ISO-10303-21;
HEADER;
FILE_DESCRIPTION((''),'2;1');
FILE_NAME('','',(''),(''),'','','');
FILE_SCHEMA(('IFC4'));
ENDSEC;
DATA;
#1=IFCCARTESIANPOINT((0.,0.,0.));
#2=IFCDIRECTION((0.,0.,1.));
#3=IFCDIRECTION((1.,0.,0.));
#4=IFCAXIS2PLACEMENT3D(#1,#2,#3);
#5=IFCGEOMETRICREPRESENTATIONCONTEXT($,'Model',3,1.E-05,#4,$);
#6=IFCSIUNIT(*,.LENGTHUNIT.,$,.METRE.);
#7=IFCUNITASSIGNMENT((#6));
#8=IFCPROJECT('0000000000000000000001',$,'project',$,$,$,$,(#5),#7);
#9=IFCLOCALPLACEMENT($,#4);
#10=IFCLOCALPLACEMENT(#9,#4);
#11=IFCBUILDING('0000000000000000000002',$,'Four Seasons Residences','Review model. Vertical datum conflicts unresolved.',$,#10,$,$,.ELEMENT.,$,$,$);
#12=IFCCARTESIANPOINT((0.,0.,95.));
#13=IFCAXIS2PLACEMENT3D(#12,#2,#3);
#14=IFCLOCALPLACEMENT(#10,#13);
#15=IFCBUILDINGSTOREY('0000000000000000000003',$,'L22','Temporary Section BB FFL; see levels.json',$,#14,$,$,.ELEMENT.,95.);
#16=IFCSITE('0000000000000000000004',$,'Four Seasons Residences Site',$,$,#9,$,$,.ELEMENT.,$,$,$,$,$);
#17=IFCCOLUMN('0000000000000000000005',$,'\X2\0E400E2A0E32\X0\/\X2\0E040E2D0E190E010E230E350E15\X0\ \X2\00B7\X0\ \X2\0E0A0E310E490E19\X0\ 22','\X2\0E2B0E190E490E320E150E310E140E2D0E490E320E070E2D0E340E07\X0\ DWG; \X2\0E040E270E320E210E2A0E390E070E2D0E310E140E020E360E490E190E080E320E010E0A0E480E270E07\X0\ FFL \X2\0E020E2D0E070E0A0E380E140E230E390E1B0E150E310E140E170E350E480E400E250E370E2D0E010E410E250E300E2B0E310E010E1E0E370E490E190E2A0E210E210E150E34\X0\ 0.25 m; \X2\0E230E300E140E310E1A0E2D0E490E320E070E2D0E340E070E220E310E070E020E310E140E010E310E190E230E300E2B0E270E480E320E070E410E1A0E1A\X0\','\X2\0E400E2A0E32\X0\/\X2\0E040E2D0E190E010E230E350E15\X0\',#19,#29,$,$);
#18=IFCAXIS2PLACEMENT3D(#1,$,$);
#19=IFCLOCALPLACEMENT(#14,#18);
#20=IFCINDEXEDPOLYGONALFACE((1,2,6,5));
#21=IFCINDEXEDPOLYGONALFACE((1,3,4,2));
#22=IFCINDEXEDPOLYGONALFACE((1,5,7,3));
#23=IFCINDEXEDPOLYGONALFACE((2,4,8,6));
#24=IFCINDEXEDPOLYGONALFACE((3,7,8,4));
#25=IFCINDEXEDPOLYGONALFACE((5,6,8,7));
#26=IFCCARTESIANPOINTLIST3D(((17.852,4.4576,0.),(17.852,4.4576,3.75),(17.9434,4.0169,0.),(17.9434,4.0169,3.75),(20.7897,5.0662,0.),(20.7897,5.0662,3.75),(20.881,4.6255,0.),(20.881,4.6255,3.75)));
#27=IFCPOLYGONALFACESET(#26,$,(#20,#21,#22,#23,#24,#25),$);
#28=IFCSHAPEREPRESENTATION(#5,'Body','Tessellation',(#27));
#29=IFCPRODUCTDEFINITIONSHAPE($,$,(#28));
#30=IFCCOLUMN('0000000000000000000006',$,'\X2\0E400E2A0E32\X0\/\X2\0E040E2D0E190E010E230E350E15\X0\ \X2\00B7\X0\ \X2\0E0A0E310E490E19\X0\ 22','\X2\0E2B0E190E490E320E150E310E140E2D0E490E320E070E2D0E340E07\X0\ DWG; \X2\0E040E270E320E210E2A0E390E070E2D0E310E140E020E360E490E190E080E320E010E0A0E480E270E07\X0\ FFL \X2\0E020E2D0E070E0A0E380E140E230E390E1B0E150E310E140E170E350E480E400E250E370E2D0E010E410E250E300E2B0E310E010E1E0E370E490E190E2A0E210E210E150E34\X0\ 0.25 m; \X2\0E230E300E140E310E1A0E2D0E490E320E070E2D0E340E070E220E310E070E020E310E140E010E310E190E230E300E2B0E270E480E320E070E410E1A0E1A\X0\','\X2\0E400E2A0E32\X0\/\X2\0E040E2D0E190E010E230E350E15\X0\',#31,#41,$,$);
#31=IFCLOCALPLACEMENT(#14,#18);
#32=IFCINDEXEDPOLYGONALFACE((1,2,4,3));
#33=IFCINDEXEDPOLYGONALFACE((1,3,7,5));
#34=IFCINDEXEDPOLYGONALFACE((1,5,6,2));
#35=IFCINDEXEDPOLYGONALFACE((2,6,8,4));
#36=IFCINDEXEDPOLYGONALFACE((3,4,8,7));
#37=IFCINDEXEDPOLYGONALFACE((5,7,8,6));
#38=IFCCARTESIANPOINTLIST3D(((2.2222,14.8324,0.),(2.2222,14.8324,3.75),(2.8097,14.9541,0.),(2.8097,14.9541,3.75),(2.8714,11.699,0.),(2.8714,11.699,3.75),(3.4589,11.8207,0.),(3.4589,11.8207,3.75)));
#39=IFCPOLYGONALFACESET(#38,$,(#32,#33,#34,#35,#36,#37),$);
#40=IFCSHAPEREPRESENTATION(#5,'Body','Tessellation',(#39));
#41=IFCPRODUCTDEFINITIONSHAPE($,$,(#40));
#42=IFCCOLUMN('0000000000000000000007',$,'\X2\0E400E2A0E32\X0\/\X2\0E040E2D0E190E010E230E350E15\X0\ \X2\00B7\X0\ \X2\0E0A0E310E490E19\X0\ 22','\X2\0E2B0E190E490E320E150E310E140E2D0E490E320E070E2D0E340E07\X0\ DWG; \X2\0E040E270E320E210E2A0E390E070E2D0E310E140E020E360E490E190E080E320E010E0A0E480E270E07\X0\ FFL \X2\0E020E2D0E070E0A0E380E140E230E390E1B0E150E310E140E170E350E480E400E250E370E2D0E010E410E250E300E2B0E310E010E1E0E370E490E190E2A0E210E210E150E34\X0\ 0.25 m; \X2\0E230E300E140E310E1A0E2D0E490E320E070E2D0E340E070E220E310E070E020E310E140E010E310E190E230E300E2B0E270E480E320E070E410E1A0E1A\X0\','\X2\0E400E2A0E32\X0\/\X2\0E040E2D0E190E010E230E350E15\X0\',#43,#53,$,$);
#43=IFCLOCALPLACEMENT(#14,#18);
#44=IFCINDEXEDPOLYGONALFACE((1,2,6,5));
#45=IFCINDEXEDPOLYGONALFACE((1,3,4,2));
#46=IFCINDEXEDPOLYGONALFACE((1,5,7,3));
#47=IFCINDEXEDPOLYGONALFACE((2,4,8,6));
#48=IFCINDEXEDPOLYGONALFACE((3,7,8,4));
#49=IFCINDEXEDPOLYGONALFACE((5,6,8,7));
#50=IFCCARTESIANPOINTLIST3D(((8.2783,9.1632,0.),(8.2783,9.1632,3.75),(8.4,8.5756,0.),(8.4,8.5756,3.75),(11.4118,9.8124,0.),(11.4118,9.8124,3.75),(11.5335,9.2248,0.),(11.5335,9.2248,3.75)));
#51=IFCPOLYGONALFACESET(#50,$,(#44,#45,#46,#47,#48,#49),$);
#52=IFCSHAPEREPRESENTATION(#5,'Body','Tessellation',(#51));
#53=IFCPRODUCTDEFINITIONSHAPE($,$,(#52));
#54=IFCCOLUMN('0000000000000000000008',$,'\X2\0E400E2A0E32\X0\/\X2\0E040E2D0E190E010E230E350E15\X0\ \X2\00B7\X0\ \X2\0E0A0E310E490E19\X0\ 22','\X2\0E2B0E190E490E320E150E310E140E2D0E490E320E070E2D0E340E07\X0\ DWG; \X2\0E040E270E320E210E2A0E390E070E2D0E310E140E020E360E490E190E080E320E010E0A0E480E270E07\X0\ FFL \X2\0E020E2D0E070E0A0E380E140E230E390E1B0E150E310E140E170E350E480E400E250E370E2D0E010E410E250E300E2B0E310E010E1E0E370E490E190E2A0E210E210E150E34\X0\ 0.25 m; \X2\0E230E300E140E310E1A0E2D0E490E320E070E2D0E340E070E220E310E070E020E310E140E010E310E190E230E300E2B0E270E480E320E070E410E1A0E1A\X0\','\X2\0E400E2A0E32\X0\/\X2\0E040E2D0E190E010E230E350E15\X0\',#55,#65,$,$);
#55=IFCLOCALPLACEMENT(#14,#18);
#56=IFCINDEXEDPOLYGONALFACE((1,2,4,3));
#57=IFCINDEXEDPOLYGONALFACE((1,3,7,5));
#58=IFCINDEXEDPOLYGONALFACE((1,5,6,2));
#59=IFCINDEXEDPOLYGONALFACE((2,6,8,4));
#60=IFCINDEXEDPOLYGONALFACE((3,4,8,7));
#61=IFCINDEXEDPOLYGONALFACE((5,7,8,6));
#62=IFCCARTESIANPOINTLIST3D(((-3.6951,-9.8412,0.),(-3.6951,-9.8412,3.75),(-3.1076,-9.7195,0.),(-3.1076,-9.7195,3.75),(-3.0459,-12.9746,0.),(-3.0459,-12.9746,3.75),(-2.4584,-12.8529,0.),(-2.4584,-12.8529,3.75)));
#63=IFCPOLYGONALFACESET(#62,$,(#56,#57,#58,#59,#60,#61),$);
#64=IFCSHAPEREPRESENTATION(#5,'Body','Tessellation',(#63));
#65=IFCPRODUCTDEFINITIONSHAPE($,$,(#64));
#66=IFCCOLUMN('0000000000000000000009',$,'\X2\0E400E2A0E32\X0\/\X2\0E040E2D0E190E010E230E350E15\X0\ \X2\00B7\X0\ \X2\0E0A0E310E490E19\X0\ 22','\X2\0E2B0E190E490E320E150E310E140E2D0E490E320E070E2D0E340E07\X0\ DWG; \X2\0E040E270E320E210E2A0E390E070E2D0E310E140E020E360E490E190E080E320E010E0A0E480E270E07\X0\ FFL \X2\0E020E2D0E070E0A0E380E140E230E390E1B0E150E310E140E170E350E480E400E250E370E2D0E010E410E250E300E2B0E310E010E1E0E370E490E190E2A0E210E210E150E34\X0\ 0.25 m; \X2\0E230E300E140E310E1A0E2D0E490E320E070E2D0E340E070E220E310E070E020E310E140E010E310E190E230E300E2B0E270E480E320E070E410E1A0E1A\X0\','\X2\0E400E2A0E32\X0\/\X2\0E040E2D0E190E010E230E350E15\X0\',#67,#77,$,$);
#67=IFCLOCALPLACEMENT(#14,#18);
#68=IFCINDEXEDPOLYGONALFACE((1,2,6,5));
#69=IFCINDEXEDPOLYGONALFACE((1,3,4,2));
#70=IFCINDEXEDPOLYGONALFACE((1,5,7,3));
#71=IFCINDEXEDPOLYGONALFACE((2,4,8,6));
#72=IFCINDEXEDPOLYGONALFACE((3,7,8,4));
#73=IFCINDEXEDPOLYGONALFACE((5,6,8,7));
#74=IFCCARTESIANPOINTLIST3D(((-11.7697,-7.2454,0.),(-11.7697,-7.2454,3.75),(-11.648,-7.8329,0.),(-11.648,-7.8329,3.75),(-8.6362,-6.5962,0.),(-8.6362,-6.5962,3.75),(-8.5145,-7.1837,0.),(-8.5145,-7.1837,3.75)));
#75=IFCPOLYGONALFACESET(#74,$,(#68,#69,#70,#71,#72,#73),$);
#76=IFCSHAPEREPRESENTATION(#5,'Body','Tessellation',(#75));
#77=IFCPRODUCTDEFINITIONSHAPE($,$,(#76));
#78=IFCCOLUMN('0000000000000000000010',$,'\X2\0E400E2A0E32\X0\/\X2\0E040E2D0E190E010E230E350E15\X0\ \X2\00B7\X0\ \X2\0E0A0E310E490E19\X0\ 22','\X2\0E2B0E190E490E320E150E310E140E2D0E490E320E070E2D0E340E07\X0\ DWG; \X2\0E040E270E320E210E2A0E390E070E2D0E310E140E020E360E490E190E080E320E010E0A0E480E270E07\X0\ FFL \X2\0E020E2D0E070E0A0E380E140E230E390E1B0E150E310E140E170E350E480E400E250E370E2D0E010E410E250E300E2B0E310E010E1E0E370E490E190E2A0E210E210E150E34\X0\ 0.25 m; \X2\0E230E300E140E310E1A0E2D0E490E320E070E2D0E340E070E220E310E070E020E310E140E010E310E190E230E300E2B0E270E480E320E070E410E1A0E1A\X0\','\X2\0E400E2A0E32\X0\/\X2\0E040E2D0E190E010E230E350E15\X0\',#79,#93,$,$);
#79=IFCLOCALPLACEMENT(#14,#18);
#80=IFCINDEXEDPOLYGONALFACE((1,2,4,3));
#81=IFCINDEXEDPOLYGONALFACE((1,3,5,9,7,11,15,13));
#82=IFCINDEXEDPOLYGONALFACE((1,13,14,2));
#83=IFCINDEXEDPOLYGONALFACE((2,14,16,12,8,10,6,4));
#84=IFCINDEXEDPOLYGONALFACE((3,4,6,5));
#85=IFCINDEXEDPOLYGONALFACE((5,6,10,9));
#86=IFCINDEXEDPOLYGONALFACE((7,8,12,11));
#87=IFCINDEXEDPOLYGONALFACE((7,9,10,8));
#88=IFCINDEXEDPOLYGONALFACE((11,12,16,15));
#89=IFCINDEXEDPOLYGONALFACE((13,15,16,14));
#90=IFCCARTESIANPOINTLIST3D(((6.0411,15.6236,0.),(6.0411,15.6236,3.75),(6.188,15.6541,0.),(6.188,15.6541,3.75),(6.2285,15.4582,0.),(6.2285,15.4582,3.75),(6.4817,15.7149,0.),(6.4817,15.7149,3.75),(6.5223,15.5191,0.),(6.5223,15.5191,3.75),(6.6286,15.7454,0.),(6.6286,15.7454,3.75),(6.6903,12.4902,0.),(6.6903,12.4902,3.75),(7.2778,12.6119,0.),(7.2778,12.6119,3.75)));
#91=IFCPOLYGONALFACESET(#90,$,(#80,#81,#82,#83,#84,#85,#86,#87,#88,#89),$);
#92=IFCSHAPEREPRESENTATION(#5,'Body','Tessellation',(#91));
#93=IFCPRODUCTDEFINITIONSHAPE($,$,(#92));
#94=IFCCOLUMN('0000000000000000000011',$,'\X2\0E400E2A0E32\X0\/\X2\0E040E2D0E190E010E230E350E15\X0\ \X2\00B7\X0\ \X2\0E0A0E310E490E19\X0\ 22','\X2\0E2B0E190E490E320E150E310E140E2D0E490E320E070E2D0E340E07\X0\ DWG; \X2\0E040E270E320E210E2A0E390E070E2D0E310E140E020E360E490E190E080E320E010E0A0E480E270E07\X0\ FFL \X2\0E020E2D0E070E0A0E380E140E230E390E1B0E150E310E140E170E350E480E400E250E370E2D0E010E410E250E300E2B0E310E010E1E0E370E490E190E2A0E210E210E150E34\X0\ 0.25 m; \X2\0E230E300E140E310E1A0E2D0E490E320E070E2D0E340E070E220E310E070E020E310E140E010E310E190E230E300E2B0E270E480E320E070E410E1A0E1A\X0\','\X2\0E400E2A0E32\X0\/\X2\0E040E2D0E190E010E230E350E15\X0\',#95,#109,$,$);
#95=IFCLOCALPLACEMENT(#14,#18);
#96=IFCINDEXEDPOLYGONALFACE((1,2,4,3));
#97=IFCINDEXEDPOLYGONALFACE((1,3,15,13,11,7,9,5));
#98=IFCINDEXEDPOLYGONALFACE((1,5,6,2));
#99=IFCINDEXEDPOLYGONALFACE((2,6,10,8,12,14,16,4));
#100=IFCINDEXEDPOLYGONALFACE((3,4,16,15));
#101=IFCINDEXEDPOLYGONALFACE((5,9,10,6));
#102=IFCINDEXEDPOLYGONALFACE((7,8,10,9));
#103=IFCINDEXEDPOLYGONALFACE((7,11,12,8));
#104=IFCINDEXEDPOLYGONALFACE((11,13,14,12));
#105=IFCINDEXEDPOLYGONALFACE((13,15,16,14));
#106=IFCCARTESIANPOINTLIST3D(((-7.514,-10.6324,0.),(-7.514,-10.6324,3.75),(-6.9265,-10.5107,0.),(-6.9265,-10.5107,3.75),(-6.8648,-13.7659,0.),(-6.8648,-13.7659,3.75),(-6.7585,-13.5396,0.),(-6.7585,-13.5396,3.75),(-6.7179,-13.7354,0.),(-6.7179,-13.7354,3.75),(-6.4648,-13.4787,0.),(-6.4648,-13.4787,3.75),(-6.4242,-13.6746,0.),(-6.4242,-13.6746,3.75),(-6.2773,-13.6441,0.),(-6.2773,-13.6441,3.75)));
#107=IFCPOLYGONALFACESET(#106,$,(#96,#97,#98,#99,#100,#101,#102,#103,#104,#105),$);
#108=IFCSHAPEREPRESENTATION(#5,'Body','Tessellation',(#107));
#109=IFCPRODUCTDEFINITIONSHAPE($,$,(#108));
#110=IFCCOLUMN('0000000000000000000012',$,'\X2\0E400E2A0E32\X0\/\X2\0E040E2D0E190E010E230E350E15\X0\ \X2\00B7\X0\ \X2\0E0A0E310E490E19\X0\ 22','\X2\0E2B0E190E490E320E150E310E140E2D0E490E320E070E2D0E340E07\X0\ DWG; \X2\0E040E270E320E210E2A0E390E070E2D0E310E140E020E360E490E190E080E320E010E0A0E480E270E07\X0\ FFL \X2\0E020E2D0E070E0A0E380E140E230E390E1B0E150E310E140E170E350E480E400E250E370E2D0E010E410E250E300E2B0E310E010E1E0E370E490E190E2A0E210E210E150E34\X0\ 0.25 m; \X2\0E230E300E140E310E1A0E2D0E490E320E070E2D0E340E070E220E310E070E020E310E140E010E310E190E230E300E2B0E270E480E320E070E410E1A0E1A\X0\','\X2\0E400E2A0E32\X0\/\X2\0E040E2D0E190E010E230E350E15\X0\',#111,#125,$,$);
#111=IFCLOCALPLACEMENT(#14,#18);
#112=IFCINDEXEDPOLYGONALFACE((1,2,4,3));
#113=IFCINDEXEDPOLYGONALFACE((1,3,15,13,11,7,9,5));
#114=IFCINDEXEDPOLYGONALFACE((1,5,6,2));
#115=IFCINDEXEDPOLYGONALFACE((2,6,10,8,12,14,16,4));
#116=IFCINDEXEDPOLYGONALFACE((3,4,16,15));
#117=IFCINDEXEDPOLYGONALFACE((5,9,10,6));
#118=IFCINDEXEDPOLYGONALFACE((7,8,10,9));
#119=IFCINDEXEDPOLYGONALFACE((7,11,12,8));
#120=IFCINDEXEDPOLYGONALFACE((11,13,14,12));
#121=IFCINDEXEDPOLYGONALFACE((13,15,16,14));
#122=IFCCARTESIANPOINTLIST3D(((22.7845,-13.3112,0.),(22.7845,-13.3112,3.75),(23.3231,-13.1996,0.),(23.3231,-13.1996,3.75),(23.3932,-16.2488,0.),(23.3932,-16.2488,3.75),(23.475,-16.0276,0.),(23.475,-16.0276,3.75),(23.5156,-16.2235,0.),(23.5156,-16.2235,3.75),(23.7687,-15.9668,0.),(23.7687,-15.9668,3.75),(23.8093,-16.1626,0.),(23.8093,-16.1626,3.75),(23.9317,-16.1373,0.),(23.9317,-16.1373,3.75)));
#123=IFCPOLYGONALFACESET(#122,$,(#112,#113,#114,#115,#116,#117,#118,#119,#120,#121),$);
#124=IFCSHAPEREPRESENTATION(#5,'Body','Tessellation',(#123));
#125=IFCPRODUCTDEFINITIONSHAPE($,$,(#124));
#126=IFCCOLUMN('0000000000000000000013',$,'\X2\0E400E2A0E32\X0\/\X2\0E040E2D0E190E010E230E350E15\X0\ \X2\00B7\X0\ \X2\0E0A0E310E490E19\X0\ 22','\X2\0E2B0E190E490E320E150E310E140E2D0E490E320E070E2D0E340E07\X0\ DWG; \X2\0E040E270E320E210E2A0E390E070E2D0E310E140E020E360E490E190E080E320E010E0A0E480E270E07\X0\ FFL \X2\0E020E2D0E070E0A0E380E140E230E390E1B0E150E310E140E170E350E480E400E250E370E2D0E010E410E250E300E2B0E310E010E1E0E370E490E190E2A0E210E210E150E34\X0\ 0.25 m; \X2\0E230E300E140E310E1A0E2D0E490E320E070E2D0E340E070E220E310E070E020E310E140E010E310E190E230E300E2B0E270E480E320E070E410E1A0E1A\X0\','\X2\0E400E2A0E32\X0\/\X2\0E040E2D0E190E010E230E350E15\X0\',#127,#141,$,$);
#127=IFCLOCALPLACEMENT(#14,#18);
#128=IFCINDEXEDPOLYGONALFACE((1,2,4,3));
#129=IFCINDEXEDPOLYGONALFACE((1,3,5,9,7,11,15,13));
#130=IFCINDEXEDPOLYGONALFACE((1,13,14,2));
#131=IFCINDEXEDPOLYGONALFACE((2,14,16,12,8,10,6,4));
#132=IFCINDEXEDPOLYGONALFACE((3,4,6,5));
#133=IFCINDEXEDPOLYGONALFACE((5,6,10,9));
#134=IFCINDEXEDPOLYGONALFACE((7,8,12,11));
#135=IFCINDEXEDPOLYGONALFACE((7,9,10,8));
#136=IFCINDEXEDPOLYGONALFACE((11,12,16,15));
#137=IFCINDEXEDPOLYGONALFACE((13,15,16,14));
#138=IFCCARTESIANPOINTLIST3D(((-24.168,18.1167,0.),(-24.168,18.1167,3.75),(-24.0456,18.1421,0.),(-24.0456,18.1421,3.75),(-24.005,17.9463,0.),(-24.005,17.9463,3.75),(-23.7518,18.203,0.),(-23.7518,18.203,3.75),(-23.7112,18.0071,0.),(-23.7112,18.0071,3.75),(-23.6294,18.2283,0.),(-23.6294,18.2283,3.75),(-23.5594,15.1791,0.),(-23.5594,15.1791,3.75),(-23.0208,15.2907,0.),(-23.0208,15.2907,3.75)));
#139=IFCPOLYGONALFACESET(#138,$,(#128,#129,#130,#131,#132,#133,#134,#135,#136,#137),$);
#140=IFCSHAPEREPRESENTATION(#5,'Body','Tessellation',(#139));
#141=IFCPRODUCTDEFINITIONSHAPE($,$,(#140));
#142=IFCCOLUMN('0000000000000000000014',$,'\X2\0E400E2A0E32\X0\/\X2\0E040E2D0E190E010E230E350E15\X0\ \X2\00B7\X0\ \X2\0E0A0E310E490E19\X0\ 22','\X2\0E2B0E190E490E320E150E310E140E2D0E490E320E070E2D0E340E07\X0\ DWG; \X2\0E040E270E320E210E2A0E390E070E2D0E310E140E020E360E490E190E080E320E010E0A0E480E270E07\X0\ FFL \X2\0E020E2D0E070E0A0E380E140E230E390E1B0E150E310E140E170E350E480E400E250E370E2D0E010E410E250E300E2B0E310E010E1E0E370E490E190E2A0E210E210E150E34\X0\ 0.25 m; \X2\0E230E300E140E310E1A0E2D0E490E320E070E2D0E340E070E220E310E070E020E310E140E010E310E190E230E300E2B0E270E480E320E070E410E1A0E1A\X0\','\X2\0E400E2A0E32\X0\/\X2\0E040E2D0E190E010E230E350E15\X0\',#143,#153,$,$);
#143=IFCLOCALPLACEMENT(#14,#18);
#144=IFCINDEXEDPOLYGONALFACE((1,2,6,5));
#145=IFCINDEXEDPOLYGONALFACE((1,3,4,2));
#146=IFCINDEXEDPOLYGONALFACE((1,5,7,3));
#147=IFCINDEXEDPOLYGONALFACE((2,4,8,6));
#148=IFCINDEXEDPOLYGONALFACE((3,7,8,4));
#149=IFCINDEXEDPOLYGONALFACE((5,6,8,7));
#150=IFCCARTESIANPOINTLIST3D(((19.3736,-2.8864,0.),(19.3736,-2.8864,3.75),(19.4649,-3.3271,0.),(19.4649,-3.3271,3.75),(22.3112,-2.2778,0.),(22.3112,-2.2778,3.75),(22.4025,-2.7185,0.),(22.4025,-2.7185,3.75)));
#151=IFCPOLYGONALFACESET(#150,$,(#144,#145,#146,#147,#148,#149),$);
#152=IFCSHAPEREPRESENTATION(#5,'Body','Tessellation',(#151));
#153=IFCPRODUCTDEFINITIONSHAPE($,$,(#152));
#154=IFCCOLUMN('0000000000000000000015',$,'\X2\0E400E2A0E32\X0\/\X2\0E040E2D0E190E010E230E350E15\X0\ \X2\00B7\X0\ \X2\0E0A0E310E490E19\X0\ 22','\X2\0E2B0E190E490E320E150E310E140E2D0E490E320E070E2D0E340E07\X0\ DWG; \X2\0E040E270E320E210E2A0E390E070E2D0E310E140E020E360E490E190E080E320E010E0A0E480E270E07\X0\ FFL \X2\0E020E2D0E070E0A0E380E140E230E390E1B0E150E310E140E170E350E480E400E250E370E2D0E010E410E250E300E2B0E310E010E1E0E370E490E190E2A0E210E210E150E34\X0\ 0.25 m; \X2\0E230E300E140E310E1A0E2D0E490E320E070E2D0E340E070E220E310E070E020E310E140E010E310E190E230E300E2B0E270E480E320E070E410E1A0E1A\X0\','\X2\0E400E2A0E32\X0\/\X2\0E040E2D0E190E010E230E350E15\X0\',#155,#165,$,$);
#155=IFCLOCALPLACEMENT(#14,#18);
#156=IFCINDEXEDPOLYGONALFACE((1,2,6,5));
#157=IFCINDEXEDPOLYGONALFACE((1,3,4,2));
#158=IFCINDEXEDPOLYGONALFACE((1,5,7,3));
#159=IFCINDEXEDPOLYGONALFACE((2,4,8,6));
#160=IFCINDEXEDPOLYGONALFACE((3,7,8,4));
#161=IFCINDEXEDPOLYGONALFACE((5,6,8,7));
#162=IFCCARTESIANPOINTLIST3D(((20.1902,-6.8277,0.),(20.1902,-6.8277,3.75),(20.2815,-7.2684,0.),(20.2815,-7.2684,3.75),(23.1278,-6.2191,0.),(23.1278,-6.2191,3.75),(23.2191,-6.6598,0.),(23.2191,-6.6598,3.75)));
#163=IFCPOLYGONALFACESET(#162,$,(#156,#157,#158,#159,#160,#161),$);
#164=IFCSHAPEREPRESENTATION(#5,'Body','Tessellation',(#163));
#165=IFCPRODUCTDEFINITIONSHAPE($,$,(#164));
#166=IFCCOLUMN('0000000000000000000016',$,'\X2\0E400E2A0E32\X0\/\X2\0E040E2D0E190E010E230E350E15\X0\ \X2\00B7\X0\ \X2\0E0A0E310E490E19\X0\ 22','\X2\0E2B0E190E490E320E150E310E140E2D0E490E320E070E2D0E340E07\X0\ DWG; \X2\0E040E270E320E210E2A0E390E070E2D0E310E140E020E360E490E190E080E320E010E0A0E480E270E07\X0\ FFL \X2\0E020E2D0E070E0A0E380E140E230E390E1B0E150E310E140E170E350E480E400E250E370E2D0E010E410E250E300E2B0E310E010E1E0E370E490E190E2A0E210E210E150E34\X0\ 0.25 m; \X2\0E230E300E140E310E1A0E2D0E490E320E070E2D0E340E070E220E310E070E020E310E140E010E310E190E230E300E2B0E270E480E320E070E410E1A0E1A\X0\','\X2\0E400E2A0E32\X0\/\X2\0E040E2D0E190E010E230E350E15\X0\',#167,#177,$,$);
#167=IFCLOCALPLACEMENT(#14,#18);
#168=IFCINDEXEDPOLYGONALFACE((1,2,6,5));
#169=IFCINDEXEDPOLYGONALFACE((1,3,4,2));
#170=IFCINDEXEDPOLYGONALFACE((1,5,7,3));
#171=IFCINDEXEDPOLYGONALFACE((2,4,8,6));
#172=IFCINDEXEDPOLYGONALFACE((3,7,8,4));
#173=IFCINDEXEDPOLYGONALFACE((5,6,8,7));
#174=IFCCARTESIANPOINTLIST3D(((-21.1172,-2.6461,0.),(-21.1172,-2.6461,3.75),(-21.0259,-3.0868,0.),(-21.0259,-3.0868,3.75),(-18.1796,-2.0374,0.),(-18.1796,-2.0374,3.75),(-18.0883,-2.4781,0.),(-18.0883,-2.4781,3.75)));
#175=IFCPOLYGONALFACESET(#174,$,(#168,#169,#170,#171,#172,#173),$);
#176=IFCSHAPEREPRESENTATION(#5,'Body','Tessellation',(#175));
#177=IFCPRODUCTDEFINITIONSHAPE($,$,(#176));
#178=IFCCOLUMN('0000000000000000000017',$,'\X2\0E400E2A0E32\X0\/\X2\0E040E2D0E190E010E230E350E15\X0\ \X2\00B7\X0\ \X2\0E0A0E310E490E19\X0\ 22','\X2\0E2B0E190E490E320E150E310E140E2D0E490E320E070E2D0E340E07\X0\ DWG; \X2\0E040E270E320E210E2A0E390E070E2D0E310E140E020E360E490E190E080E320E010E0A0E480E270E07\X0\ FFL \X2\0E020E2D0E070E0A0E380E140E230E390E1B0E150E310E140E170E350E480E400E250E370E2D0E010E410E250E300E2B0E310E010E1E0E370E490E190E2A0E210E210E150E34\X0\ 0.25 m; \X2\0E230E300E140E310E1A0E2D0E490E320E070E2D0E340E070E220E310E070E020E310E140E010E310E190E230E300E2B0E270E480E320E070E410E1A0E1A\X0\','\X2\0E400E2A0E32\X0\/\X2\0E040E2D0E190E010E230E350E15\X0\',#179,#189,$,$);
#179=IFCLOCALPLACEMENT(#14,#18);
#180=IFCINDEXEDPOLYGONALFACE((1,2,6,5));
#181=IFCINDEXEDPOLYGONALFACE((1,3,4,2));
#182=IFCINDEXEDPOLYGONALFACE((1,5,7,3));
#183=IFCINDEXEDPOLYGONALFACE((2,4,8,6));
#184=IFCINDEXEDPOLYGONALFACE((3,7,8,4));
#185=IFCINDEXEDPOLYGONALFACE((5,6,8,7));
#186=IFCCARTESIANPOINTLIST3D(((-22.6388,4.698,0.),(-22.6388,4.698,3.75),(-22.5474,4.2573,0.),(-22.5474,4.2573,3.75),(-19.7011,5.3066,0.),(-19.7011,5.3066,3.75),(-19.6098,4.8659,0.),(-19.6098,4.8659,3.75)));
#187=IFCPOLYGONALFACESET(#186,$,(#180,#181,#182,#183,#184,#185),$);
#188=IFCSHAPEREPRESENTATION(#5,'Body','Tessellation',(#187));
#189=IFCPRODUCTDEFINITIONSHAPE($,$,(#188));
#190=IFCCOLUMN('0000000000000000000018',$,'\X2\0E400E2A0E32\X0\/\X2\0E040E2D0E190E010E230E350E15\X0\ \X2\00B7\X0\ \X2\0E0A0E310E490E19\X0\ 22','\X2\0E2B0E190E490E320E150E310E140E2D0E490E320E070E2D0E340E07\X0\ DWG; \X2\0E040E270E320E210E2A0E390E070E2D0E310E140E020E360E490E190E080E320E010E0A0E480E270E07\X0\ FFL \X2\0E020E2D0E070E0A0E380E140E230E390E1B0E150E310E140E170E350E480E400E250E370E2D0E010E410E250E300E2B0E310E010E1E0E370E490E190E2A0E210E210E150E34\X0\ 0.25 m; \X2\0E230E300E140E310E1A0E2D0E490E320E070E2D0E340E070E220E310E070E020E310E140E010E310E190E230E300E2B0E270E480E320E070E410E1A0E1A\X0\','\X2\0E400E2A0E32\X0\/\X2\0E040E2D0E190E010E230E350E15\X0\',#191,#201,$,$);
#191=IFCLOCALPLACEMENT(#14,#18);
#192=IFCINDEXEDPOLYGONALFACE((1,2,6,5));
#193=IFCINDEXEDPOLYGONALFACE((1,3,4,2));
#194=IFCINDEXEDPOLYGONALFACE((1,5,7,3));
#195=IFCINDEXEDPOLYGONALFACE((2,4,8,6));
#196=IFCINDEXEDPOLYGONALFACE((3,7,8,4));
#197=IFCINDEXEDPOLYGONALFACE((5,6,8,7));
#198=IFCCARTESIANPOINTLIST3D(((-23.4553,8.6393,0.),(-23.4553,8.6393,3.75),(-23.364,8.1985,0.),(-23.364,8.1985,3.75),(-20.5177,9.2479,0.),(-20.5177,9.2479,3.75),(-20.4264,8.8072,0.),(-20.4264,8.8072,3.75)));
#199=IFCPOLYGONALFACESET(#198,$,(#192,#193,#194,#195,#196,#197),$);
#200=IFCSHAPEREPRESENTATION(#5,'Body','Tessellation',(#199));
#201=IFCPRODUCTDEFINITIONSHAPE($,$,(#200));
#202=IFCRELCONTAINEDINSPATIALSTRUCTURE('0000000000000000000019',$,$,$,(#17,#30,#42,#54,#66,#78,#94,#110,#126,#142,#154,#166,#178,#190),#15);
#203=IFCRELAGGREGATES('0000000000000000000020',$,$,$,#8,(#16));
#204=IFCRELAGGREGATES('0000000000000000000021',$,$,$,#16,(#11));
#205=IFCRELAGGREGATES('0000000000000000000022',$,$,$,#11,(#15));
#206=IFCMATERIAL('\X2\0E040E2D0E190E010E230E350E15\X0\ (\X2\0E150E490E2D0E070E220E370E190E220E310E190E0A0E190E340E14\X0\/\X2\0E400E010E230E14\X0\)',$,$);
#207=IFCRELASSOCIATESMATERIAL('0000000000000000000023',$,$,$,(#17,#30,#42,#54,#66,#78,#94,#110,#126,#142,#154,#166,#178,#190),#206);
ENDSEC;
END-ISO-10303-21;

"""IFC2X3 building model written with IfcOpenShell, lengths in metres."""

from ifc_helpers import new_model, si_unit, frame, origin_with_axes, place, context, project, spatial, polyline, outline, extrude, material, element, save


model = new_model("IFC2X3")

# Units and contexts
model_context = context("Model", 3, precision=1e-05, world=origin_with_axes())
ifc_project = project(units=[si_unit("LENGTHUNIT", "METRE")], contexts=[model_context])

# Site, building, storey
site_placement = place(None, origin_with_axes())
site = spatial("IfcSite", under=ifc_project, at=site_placement, Name="Four Seasons Residences Site", CompositionType="ELEMENT")
building_placement = place(site_placement, origin_with_axes())
building = spatial("IfcBuilding", under=site, at=building_placement, Name="Four Seasons Residences", Description="Review model. Vertical datum conflicts unresolved.", CompositionType="ELEMENT")
storey_placement = place(building_placement, frame((0.0, 0.0, 95.0), z_axis=(0.0, 0.0, 1.0), x_axis=(1.0, 0.0, 0.0)))
storey = spatial("IfcBuildingStorey", under=building, at=storey_placement, Name="L22", Description="Temporary Section BB FFL; see levels.json", CompositionType="ELEMENT", Elevation=95.0)

# Columns
ifc_material_1 = material(Name="คอนกรีต (ต้องยืนยันชนิด/เกรด)")
column_1_placement = place(storey_placement, origin_with_axes())
element("IfcColumn", 1, at=column_1_placement, inside=storey, material=ifc_material_1, Name="เสา/คอนกรีต · ชั้น 22", Description="หน้าตัดอ้างอิง DWG; ความสูงอัดขึ้นจากช่วง FFL ของชุดรูปตัดที่เลือกและหักพื้นสมมติ 0.25 m; ระดับอ้างอิงยังขัดกันระหว่างแบบ", ObjectType="เสา/คอนกรีต", context=model_context, shape_type="SweptSolid", body=[
    extrude(outline(polyline([(20.7897, 5.0662), (20.881, 4.6255), (17.9434, 4.0169), (17.852, 4.4576), (20.7897, 5.0662)])), origin_with_axes(), (0.0, 0.0, 1.0), 3.75),
])
column_2_placement = place(storey_placement, origin_with_axes())
element("IfcColumn", 2, at=column_2_placement, inside=storey, material=ifc_material_1, Name="เสา/คอนกรีต · ชั้น 22", Description="หน้าตัดอ้างอิง DWG; ความสูงอัดขึ้นจากช่วง FFL ของชุดรูปตัดที่เลือกและหักพื้นสมมติ 0.25 m; ระดับอ้างอิงยังขัดกันระหว่างแบบ", ObjectType="เสา/คอนกรีต", context=model_context, shape_type="SweptSolid", body=[
    extrude(outline(polyline([(2.8097, 14.9541), (3.4589, 11.8207), (2.8714, 11.699), (2.2222, 14.8324), (2.8097, 14.9541)])), origin_with_axes(), (0.0, 0.0, 1.0), 3.75),
])
column_3_placement = place(storey_placement, origin_with_axes())
element("IfcColumn", 3, at=column_3_placement, inside=storey, material=ifc_material_1, Name="เสา/คอนกรีต · ชั้น 22", Description="หน้าตัดอ้างอิง DWG; ความสูงอัดขึ้นจากช่วง FFL ของชุดรูปตัดที่เลือกและหักพื้นสมมติ 0.25 m; ระดับอ้างอิงยังขัดกันระหว่างแบบ", ObjectType="เสา/คอนกรีต", context=model_context, shape_type="SweptSolid", body=[
    extrude(outline(polyline([(11.5335, 9.2248), (8.4, 8.5756), (8.2783, 9.1632), (11.4118, 9.8124), (11.5335, 9.2248)])), origin_with_axes(), (0.0, 0.0, 1.0), 3.75),
])
column_4_placement = place(storey_placement, origin_with_axes())
element("IfcColumn", 4, at=column_4_placement, inside=storey, material=ifc_material_1, Name="เสา/คอนกรีต · ชั้น 22", Description="หน้าตัดอ้างอิง DWG; ความสูงอัดขึ้นจากช่วง FFL ของชุดรูปตัดที่เลือกและหักพื้นสมมติ 0.25 m; ระดับอ้างอิงยังขัดกันระหว่างแบบ", ObjectType="เสา/คอนกรีต", context=model_context, shape_type="SweptSolid", body=[
    extrude(outline(polyline([(-3.1076, -9.7195), (-2.4584, -12.8529), (-3.0459, -12.9746), (-3.6951, -9.8412), (-3.1076, -9.7195)])), origin_with_axes(), (0.0, 0.0, 1.0), 3.75),
])
column_5_placement = place(storey_placement, origin_with_axes())
element("IfcColumn", 5, at=column_5_placement, inside=storey, material=ifc_material_1, Name="เสา/คอนกรีต · ชั้น 22", Description="หน้าตัดอ้างอิง DWG; ความสูงอัดขึ้นจากช่วง FFL ของชุดรูปตัดที่เลือกและหักพื้นสมมติ 0.25 m; ระดับอ้างอิงยังขัดกันระหว่างแบบ", ObjectType="เสา/คอนกรีต", context=model_context, shape_type="SweptSolid", body=[
    extrude(outline(polyline([(-8.5145, -7.1837), (-11.648, -7.8329), (-11.7697, -7.2454), (-8.6362, -6.5962), (-8.5145, -7.1837)])), origin_with_axes(), (0.0, 0.0, 1.0), 3.75),
])
column_6_placement = place(storey_placement, origin_with_axes())
element("IfcColumn", 6, at=column_6_placement, inside=storey, material=ifc_material_1, Name="เสา/คอนกรีต · ชั้น 22", Description="หน้าตัดอ้างอิง DWG; ความสูงอัดขึ้นจากช่วง FFL ของชุดรูปตัดที่เลือกและหักพื้นสมมติ 0.25 m; ระดับอ้างอิงยังขัดกันระหว่างแบบ", ObjectType="เสา/คอนกรีต", context=model_context, shape_type="SweptSolid", body=[
    extrude(outline(polyline([(6.6286, 15.7454), (6.4817, 15.7149), (6.5223, 15.5191), (6.2285, 15.4582), (6.188, 15.6541), (6.0411, 15.6236), (6.6903, 12.4902), (7.2778, 12.6119), (6.6286, 15.7454)])), origin_with_axes(), (0.0, 0.0, 1.0), 3.75),
])
column_7_placement = place(storey_placement, origin_with_axes())
element("IfcColumn", 7, at=column_7_placement, inside=storey, material=ifc_material_1, Name="เสา/คอนกรีต · ชั้น 22", Description="หน้าตัดอ้างอิง DWG; ความสูงอัดขึ้นจากช่วง FFL ของชุดรูปตัดที่เลือกและหักพื้นสมมติ 0.25 m; ระดับอ้างอิงยังขัดกันระหว่างแบบ", ObjectType="เสา/คอนกรีต", context=model_context, shape_type="SweptSolid", body=[
    extrude(outline(polyline([(-6.2773, -13.6441), (-6.9265, -10.5107), (-7.514, -10.6324), (-6.8648, -13.7659), (-6.7179, -13.7354), (-6.7585, -13.5396), (-6.4648, -13.4787), (-6.4242, -13.6746), (-6.2773, -13.6441)])), origin_with_axes(), (0.0, 0.0, 1.0), 3.75),
])
column_8_placement = place(storey_placement, origin_with_axes())
element("IfcColumn", 8, at=column_8_placement, inside=storey, material=ifc_material_1, Name="เสา/คอนกรีต · ชั้น 22", Description="หน้าตัดอ้างอิง DWG; ความสูงอัดขึ้นจากช่วง FFL ของชุดรูปตัดที่เลือกและหักพื้นสมมติ 0.25 m; ระดับอ้างอิงยังขัดกันระหว่างแบบ", ObjectType="เสา/คอนกรีต", context=model_context, shape_type="SweptSolid", body=[
    extrude(outline(polyline([(23.9317, -16.1373), (23.3231, -13.1996), (22.7845, -13.3112), (23.3932, -16.2488), (23.5156, -16.2235), (23.475, -16.0276), (23.7687, -15.9668), (23.8093, -16.1626), (23.9317, -16.1373)])), origin_with_axes(), (0.0, 0.0, 1.0), 3.75),
])
column_9_placement = place(storey_placement, origin_with_axes())
element("IfcColumn", 9, at=column_9_placement, inside=storey, material=ifc_material_1, Name="เสา/คอนกรีต · ชั้น 22", Description="หน้าตัดอ้างอิง DWG; ความสูงอัดขึ้นจากช่วง FFL ของชุดรูปตัดที่เลือกและหักพื้นสมมติ 0.25 m; ระดับอ้างอิงยังขัดกันระหว่างแบบ", ObjectType="เสา/คอนกรีต", context=model_context, shape_type="SweptSolid", body=[
    extrude(outline(polyline([(-24.168, 18.1167), (-23.5594, 15.1791), (-23.0208, 15.2907), (-23.6294, 18.2283), (-23.7518, 18.203), (-23.7112, 18.0071), (-24.005, 17.9463), (-24.0456, 18.1421), (-24.168, 18.1167)])), origin_with_axes(), (0.0, 0.0, 1.0), 3.75),
])
column_10_placement = place(storey_placement, origin_with_axes())
element("IfcColumn", 10, at=column_10_placement, inside=storey, material=ifc_material_1, Name="เสา/คอนกรีต · ชั้น 22", Description="หน้าตัดอ้างอิง DWG; ความสูงอัดขึ้นจากช่วง FFL ของชุดรูปตัดที่เลือกและหักพื้นสมมติ 0.25 m; ระดับอ้างอิงยังขัดกันระหว่างแบบ", ObjectType="เสา/คอนกรีต", context=model_context, shape_type="SweptSolid", body=[
    extrude(outline(polyline([(22.3112, -2.2778), (22.4025, -2.7185), (19.4649, -3.3271), (19.3736, -2.8864), (22.3112, -2.2778)])), origin_with_axes(), (0.0, 0.0, 1.0), 3.75),
])
column_11_placement = place(storey_placement, origin_with_axes())
element("IfcColumn", 11, at=column_11_placement, inside=storey, material=ifc_material_1, Name="เสา/คอนกรีต · ชั้น 22", Description="หน้าตัดอ้างอิง DWG; ความสูงอัดขึ้นจากช่วง FFL ของชุดรูปตัดที่เลือกและหักพื้นสมมติ 0.25 m; ระดับอ้างอิงยังขัดกันระหว่างแบบ", ObjectType="เสา/คอนกรีต", context=model_context, shape_type="SweptSolid", body=[
    extrude(outline(polyline([(23.1278, -6.2191), (23.2191, -6.6598), (20.2815, -7.2684), (20.1902, -6.8277), (23.1278, -6.2191)])), origin_with_axes(), (0.0, 0.0, 1.0), 3.75),
])
column_12_placement = place(storey_placement, origin_with_axes())
element("IfcColumn", 12, at=column_12_placement, inside=storey, material=ifc_material_1, Name="เสา/คอนกรีต · ชั้น 22", Description="หน้าตัดอ้างอิง DWG; ความสูงอัดขึ้นจากช่วง FFL ของชุดรูปตัดที่เลือกและหักพื้นสมมติ 0.25 m; ระดับอ้างอิงยังขัดกันระหว่างแบบ", ObjectType="เสา/คอนกรีต", context=model_context, shape_type="SweptSolid", body=[
    extrude(outline(polyline([(-18.1796, -2.0374), (-18.0883, -2.4781), (-21.0259, -3.0868), (-21.1172, -2.6461), (-18.1796, -2.0374)])), origin_with_axes(), (0.0, 0.0, 1.0), 3.75),
])
column_13_placement = place(storey_placement, origin_with_axes())
element("IfcColumn", 13, at=column_13_placement, inside=storey, material=ifc_material_1, Name="เสา/คอนกรีต · ชั้น 22", Description="หน้าตัดอ้างอิง DWG; ความสูงอัดขึ้นจากช่วง FFL ของชุดรูปตัดที่เลือกและหักพื้นสมมติ 0.25 m; ระดับอ้างอิงยังขัดกันระหว่างแบบ", ObjectType="เสา/คอนกรีต", context=model_context, shape_type="SweptSolid", body=[
    extrude(outline(polyline([(-19.7011, 5.3066), (-19.6098, 4.8659), (-22.5474, 4.2573), (-22.6388, 4.698), (-19.7011, 5.3066)])), origin_with_axes(), (0.0, 0.0, 1.0), 3.75),
])
column_14_placement = place(storey_placement, origin_with_axes())
element("IfcColumn", 14, at=column_14_placement, inside=storey, material=ifc_material_1, Name="เสา/คอนกรีต · ชั้น 22", Description="หน้าตัดอ้างอิง DWG; ความสูงอัดขึ้นจากช่วง FFL ของชุดรูปตัดที่เลือกและหักพื้นสมมติ 0.25 m; ระดับอ้างอิงยังขัดกันระหว่างแบบ", ObjectType="เสา/คอนกรีต", context=model_context, shape_type="SweptSolid", body=[
    extrude(outline(polyline([(-20.5177, 9.2479), (-20.4264, 8.8072), (-23.364, 8.1985), (-23.4553, 8.6393), (-20.5177, 9.2479)])), origin_with_axes(), (0.0, 0.0, 1.0), 3.75),
])

save(model, "model.ifc")
